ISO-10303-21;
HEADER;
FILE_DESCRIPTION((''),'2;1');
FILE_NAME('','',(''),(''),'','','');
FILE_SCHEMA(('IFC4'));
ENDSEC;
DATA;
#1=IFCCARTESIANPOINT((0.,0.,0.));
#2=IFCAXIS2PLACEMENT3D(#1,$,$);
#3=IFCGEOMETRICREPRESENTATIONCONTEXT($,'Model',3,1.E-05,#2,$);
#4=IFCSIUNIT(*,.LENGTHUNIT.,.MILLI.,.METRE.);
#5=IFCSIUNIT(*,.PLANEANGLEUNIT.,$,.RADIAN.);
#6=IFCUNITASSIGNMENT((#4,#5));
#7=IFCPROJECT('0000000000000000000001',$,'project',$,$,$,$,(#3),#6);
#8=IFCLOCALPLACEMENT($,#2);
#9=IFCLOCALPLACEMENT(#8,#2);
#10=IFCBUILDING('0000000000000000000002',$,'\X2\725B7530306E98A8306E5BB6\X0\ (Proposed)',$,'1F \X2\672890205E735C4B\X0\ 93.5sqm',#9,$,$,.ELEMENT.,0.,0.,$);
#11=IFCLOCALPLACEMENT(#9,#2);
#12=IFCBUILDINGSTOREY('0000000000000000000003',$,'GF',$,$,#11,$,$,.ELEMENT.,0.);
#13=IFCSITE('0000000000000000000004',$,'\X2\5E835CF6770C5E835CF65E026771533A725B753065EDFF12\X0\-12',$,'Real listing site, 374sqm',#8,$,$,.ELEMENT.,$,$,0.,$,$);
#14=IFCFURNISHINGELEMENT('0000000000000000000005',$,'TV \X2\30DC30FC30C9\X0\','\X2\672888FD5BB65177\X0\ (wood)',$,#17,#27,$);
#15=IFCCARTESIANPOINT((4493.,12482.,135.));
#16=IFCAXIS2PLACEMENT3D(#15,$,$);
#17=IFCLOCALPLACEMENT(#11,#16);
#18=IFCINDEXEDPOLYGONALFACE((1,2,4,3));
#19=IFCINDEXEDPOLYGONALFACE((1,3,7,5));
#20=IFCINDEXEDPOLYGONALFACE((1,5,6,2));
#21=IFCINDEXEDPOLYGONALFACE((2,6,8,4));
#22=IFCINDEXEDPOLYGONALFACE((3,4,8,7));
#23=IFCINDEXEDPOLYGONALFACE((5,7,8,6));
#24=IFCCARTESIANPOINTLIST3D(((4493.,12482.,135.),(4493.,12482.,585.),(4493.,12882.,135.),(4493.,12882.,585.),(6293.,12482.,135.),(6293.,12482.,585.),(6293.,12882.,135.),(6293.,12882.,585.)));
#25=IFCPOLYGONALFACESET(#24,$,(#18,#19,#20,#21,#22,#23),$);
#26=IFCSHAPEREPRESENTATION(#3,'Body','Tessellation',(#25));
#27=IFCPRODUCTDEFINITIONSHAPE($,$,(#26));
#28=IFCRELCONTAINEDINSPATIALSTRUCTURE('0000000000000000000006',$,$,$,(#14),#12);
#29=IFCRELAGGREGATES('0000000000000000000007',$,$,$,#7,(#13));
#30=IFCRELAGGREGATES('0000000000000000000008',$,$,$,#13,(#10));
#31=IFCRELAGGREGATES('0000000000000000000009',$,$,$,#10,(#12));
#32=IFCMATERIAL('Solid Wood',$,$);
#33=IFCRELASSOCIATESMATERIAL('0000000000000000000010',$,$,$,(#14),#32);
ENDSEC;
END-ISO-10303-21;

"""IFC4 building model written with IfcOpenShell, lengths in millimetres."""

from ifc_helpers import new_model, si_unit, frame, frame_2d, origin, place, context, project, spatial, rectangle, extrude, material, element, save


model = new_model("IFC4")

# Units and contexts
model_context = context("Model", 3, precision=1e-05, world=origin())
ifc_project = project(units=[si_unit("LENGTHUNIT", "METRE", prefix="MILLI"), si_unit("PLANEANGLEUNIT", "RADIAN")], contexts=[model_context])

# Site, building, storey
site_placement = place(None, origin())
site = spatial("IfcSite", under=ifc_project, at=site_placement, Name="広島県広島市東区牛田旭２-12", ObjectType="Real listing site, 374sqm", CompositionType="ELEMENT", RefElevation=0.0)
building_placement = place(site_placement, origin())
building = spatial("IfcBuilding", under=site, at=building_placement, Name="牛田の風の家 (Proposed)", ObjectType="1F 木造平屋 93.5sqm", CompositionType="ELEMENT", ElevationOfRefHeight=0.0, ElevationOfTerrain=0.0)
storey_placement = place(building_placement, origin())
storey = spatial("IfcBuildingStorey", under=building, at=storey_placement, Name="GF", CompositionType="ELEMENT", Elevation=0.0)

# Shared definitions
ifc_material_1 = material(Name="Solid Wood")

# Furnishing element
furnishing_1_placement = place(storey_placement, frame((4493.0, 12482.0, 135.0)))
element("IfcFurnishingElement", 1, at=furnishing_1_placement, inside=storey, material=ifc_material_1, Name="TV ボード", Description="木製家具 (wood)", context=model_context, shape_type="SweptSolid", body=[
    extrude(rectangle(XDim=1800.0, YDim=400.0, at=frame_2d((900.0, 200.0))), frame((4493.0, 12482.0, 135.0)), (0.0, 0.0, 1.0), 450.0),
])

save(model, "model.ifc")
